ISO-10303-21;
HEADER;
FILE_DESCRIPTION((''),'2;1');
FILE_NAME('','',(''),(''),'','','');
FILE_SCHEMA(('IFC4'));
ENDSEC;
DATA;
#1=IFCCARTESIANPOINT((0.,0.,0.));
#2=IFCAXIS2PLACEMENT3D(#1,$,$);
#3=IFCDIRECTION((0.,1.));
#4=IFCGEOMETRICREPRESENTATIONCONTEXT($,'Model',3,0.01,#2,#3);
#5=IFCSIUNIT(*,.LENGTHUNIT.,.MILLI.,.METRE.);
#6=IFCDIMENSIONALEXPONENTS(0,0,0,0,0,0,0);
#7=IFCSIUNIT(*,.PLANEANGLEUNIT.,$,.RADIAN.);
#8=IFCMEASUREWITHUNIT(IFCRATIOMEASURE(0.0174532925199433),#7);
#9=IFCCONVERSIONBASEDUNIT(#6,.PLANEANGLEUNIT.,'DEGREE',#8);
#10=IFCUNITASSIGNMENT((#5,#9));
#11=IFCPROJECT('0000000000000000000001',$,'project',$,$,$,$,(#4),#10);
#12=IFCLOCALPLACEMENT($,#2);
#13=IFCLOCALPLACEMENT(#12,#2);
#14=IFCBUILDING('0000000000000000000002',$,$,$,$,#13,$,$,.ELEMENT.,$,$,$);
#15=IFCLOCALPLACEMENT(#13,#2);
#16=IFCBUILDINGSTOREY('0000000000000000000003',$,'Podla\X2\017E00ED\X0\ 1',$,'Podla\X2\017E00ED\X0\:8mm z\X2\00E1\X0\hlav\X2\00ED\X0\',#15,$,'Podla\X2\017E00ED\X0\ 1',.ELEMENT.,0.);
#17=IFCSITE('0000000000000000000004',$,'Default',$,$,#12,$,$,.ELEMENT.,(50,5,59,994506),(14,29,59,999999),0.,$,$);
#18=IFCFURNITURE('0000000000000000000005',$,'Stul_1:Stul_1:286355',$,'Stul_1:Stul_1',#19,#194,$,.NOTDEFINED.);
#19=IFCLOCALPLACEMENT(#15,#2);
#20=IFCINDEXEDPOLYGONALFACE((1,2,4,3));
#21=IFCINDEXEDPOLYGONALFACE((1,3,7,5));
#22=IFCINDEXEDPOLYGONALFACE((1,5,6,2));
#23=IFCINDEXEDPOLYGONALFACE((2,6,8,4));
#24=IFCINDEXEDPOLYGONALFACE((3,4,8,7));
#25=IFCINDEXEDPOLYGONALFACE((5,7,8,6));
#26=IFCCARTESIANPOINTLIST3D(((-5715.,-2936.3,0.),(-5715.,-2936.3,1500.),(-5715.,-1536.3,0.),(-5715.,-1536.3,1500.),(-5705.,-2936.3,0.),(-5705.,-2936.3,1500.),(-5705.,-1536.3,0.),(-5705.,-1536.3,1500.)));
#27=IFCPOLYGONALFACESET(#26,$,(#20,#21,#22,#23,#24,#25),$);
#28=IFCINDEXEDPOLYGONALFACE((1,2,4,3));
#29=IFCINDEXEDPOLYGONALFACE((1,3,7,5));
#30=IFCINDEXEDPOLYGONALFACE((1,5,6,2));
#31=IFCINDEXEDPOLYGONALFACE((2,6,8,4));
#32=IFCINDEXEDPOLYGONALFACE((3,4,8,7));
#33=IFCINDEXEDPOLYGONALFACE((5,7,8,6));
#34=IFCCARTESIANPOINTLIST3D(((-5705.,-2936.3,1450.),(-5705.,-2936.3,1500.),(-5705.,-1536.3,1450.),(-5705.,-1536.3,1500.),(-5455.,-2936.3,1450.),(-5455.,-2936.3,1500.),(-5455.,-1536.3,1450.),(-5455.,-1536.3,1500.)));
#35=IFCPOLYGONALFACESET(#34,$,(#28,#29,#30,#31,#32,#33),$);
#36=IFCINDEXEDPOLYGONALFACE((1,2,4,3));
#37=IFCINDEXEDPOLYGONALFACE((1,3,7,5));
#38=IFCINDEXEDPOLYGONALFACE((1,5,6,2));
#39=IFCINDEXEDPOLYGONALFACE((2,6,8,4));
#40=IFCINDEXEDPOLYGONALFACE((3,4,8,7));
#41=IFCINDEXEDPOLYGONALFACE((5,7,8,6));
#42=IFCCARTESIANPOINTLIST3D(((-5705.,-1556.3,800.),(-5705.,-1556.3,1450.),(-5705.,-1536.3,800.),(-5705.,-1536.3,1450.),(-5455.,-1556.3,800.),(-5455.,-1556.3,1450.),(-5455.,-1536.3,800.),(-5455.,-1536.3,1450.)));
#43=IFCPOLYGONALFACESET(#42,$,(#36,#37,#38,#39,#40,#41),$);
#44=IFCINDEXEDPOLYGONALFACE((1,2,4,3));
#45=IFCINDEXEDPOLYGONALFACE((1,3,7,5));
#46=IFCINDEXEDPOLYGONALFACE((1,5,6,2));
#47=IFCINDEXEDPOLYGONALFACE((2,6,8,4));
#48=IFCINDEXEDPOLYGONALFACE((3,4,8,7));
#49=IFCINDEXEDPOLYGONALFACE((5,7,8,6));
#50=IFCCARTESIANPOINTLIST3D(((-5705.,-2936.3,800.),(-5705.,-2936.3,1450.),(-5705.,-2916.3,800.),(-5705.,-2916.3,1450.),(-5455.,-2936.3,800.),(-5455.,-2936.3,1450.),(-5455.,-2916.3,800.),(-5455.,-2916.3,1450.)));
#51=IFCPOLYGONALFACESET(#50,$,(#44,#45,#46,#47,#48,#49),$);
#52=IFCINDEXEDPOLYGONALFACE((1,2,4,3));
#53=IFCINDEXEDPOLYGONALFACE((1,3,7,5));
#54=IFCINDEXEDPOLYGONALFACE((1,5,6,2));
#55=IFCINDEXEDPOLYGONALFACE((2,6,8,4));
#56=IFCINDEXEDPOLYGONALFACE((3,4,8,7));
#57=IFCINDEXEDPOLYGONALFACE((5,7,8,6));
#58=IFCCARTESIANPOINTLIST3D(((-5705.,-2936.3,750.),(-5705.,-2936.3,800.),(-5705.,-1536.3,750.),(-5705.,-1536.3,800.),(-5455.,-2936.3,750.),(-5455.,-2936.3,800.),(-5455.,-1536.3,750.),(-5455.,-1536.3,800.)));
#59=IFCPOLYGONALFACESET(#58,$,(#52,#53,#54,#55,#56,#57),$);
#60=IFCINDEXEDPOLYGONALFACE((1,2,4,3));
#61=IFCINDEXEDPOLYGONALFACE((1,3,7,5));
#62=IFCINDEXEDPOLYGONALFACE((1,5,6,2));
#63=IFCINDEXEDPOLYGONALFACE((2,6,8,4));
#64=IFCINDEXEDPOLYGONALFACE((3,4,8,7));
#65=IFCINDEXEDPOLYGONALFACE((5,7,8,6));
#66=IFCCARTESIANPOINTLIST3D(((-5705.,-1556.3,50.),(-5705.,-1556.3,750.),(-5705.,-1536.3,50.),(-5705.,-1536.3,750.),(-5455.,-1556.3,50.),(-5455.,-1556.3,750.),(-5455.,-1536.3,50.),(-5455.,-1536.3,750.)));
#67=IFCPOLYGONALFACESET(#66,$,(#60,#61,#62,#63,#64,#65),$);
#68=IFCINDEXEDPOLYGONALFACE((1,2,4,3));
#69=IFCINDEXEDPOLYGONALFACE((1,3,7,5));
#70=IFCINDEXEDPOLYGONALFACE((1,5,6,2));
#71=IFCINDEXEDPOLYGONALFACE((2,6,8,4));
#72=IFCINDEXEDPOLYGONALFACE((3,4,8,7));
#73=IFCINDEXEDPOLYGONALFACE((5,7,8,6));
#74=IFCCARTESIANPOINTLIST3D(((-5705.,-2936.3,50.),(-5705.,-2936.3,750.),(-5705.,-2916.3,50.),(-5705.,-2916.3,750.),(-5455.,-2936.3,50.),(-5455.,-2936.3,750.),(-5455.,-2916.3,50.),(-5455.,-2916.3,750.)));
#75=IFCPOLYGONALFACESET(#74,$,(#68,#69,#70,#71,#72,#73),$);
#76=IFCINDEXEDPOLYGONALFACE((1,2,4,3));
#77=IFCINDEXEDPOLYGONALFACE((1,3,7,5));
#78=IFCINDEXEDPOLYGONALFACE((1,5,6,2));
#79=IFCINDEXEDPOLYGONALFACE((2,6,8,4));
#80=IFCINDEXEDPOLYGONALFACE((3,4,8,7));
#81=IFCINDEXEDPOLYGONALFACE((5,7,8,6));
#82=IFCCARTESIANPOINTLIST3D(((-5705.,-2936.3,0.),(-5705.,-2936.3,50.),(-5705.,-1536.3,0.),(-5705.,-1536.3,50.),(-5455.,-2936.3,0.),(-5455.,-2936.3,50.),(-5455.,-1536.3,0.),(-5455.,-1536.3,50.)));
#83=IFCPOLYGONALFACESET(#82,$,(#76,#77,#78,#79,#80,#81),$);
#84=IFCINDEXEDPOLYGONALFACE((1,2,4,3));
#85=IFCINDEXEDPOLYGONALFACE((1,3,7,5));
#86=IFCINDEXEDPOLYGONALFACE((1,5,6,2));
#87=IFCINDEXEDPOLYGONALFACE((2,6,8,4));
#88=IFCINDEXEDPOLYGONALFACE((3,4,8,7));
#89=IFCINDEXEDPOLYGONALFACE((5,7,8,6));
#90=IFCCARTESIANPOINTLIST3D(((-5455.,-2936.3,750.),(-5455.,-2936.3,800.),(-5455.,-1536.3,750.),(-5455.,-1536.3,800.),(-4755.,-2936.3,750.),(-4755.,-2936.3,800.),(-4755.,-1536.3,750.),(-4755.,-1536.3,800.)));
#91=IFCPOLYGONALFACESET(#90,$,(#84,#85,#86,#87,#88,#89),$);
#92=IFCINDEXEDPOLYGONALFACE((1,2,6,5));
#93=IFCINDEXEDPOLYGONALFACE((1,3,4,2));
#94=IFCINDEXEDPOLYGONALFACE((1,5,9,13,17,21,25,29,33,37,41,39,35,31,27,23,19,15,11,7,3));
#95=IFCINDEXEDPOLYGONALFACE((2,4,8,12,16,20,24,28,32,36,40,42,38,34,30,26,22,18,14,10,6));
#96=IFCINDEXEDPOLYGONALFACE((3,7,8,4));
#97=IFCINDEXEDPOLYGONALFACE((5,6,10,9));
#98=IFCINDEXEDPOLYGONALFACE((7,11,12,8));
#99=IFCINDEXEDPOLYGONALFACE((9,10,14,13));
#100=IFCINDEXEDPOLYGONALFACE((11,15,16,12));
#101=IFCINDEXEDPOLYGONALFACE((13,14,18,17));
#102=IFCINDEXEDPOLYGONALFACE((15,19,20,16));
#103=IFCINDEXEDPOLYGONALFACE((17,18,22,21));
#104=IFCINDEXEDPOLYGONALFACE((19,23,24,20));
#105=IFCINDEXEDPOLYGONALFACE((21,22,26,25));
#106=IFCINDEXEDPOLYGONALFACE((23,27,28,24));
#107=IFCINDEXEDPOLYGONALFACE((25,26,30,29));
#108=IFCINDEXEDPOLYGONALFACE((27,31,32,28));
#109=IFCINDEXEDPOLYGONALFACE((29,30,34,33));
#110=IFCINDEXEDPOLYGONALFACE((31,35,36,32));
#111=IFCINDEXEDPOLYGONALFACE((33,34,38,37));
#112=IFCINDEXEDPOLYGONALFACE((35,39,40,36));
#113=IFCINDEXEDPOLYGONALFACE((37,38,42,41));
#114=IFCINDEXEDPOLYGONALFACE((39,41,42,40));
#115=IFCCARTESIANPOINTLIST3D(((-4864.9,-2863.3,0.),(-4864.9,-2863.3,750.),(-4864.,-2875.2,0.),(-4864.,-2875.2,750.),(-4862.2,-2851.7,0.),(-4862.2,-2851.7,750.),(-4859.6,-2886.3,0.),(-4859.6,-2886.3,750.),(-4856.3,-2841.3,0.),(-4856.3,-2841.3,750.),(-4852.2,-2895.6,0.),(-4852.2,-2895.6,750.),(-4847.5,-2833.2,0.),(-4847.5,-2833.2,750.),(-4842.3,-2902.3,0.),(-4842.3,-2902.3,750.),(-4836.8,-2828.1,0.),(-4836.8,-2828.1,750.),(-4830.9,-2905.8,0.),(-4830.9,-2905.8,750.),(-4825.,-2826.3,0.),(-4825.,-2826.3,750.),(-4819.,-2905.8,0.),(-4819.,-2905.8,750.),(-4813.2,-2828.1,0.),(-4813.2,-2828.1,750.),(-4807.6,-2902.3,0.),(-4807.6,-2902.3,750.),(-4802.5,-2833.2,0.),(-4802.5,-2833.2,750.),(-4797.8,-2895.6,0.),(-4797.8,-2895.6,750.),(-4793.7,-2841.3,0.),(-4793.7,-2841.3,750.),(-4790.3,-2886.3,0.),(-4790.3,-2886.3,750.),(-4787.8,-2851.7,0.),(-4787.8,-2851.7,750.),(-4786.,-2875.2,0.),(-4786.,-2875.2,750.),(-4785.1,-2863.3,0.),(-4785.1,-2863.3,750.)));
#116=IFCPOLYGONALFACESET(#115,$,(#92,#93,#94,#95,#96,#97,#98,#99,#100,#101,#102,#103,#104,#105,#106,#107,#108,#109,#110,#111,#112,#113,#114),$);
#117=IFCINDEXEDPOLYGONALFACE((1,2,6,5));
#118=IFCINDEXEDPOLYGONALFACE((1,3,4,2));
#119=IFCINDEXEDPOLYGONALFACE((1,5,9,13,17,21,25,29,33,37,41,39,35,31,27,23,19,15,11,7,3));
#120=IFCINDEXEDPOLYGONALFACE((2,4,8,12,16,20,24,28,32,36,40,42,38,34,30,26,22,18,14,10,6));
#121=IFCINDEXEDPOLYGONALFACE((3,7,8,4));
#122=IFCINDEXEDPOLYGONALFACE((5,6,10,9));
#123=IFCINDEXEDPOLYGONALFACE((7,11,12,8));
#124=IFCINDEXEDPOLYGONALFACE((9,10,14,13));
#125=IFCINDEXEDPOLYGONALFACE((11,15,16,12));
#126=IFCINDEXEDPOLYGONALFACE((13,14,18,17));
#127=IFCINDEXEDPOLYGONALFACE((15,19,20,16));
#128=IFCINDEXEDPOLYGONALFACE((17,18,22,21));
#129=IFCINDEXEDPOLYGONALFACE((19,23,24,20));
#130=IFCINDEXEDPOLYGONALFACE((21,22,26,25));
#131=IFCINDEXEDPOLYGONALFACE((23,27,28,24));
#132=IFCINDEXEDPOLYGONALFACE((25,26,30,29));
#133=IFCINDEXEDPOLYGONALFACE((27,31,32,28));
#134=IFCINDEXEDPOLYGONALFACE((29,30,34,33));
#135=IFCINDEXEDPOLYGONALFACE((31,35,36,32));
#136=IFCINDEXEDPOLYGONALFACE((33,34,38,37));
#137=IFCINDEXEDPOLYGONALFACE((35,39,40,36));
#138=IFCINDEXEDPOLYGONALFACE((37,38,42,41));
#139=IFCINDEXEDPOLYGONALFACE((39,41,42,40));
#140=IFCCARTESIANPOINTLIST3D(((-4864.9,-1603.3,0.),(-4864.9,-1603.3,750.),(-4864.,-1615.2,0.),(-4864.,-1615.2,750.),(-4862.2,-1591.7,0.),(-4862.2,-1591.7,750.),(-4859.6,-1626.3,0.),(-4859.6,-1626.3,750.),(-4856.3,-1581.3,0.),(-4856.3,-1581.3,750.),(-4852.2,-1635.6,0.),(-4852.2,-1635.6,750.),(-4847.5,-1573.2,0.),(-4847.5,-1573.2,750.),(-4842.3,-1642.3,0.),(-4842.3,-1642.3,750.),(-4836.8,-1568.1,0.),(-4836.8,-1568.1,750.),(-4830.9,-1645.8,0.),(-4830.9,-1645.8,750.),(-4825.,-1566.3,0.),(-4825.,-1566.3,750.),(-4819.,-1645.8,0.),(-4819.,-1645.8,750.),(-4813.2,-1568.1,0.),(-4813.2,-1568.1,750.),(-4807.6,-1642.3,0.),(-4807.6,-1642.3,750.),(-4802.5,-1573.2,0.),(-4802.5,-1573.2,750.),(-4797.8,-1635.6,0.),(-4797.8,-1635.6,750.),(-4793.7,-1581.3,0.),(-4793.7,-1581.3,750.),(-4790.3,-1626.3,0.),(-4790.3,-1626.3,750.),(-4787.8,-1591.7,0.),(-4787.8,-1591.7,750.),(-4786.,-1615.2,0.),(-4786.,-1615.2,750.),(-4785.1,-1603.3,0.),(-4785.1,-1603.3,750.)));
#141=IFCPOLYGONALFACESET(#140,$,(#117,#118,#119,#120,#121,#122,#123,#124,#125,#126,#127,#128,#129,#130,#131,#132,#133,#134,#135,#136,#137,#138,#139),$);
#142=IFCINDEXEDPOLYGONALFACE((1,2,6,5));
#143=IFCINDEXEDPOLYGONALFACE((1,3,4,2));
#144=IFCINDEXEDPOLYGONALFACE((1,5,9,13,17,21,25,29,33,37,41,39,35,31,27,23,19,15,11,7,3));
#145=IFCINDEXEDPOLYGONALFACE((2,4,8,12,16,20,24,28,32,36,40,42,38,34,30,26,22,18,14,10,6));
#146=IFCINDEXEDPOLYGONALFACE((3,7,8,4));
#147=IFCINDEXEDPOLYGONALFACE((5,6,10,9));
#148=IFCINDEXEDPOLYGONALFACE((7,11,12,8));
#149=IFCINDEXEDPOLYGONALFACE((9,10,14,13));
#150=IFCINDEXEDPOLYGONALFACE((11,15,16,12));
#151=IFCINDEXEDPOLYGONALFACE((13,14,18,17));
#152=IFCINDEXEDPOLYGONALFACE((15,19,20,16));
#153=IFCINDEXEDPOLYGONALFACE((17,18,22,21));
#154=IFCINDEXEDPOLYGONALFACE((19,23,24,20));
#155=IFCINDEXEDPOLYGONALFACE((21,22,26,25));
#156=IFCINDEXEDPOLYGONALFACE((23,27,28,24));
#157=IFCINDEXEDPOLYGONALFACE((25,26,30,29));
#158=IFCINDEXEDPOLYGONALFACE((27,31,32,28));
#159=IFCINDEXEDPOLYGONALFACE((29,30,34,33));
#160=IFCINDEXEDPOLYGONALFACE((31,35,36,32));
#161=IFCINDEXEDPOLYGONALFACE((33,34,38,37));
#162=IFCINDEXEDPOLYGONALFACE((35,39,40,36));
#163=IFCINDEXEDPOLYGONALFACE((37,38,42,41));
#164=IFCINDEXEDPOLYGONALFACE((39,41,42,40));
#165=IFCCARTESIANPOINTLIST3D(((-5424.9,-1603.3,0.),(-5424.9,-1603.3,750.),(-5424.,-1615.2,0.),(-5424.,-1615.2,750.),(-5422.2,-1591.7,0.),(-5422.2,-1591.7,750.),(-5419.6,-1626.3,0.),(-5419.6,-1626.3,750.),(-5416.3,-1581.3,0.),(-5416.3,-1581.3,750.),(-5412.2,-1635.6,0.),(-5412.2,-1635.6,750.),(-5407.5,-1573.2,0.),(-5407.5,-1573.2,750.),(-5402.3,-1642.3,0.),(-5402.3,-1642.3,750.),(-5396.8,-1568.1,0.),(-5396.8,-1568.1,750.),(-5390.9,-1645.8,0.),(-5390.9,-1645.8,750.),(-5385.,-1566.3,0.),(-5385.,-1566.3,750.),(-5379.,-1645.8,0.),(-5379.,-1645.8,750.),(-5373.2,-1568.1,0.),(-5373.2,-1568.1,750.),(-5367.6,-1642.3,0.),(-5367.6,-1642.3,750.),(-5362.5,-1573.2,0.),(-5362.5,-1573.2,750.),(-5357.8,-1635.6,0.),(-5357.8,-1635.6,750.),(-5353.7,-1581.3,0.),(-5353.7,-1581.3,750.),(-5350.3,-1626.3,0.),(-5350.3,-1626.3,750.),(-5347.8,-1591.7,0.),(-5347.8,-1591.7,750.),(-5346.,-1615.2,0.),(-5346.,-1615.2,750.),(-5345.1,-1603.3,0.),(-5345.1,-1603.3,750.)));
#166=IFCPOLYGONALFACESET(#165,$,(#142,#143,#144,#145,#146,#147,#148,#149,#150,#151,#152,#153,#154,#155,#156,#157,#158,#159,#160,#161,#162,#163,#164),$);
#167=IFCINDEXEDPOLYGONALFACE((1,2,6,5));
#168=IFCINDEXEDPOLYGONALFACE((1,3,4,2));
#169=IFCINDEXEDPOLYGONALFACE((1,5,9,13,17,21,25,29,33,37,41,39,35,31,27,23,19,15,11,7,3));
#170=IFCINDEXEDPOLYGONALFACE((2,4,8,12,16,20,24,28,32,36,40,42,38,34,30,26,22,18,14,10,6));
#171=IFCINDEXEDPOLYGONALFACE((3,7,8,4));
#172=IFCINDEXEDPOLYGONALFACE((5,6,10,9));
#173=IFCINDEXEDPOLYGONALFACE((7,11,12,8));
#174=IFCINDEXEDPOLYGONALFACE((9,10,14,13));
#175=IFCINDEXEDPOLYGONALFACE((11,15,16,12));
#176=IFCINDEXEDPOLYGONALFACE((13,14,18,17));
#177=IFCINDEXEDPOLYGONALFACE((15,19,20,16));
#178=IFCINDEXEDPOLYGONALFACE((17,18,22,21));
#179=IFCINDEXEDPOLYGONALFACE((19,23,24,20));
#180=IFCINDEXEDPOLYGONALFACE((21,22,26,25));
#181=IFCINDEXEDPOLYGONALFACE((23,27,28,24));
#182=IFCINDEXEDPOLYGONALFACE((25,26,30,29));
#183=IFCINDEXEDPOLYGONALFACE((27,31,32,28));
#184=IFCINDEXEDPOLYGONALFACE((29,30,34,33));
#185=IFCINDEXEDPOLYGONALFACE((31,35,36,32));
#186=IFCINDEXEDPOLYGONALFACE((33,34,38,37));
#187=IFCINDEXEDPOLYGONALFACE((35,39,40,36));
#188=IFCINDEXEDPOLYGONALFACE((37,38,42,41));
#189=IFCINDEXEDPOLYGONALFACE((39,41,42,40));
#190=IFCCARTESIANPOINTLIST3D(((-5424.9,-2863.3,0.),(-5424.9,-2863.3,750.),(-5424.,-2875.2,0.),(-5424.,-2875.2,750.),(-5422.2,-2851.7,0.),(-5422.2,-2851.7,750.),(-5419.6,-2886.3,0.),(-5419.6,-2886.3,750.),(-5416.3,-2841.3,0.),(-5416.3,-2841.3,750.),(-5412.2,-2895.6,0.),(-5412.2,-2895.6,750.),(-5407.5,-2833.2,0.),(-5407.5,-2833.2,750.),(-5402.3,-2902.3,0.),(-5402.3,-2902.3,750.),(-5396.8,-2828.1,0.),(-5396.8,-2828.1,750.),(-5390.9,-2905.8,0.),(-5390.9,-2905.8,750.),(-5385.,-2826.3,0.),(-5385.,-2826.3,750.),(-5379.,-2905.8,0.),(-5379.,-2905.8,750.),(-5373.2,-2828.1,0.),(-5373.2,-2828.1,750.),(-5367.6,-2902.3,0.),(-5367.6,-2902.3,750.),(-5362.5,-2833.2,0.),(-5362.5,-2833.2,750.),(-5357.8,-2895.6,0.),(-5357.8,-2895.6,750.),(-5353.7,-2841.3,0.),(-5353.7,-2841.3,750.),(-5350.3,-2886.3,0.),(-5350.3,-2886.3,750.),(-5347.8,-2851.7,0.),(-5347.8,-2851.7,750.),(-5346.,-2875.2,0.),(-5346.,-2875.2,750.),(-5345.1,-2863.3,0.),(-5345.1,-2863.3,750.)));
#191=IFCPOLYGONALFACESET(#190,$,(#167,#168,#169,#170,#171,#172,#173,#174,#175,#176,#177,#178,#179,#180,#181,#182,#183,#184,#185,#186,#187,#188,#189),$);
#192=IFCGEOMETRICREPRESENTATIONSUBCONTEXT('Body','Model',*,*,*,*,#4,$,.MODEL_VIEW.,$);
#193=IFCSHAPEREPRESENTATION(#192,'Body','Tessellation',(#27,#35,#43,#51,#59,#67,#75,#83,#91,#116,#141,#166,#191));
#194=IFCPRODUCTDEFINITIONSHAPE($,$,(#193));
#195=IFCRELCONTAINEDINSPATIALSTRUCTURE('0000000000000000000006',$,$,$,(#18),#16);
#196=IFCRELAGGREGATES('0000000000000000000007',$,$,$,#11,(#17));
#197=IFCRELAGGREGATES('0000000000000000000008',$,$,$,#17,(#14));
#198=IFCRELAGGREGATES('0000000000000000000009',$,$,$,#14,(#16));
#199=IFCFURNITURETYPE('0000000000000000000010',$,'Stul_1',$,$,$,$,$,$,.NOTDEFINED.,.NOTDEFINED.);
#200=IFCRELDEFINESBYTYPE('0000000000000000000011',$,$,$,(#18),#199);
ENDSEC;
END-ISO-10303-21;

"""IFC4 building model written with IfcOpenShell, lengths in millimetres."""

from ifc_helpers import new_model, entity, si_unit, converted_unit, direction, frame, frame_2d, origin, origin_2d_with_axis, place, context, subcontext, project, spatial, rectangle, circle, extrude, source, transform, mapped, type_object, type_shapes, element, save


model = new_model("IFC4")

# Units and contexts
model_context = context("Model", 3, precision=0.01, world=origin(), true_north=direction((0.0, 1.0)))
body_context = subcontext(model_context, "Body", "Model", "MODEL_VIEW")
ifc_project = project(units=[si_unit("LENGTHUNIT", "METRE", prefix="MILLI"), converted_unit("PLANEANGLEUNIT", "DEGREE", entity("IfcRatioMeasure", 0.0174532925199433), si_unit("PLANEANGLEUNIT", "RADIAN"), dimensions=[0, 0, 0, 0, 0, 0, 0])], contexts=[model_context])

# Site, building, storey
site_placement = place(None, origin())
site = spatial("IfcSite", under=ifc_project, at=site_placement, Name="Default", CompositionType="ELEMENT", RefLatitude=(50, 5, 59, 994506), RefLongitude=(14, 29, 59, 999999), RefElevation=0.0)
building_placement = place(site_placement, origin())
building = spatial("IfcBuilding", under=site, at=building_placement, CompositionType="ELEMENT")
storey_placement = place(building_placement, origin())
storey = spatial("IfcBuildingStorey", under=building, at=storey_placement, Name="Podlaží 1", ObjectType="Podlaží:8mm záhlaví", LongName="Podlaží 1", CompositionType="ELEMENT", Elevation=0.0)

# Furniture
furniture_type = type_object("IfcFurnitureType", Name="Stul_1", AssemblyPlace="NOTDEFINED", PredefinedType="NOTDEFINED")
shared_shape_1 = source(origin(), body_context, "Body", "SweptSolid", [
    extrude(rectangle(XDim=1400.0, YDim=10.0, at=origin_2d_with_axis()), frame((0.0, 605.0, 0.0), z_axis=(0.0, 0.0, 1.0), x_axis=(-1.0, 0.0, 0.0)), (0.0, 0.0, 1.0), 1500.0),
    extrude(rectangle(XDim=1400.0, YDim=250.0, at=frame_2d((0.0, 0.0), x_axis=(1.0, 0.0))), frame((0.0, 475.0, 1450.0), z_axis=(0.0, 0.0, 1.0), x_axis=(-1.0, 0.0, 0.0)), (0.0, 0.0, 1.0), 50.0),
    extrude(rectangle(XDim=20.0, YDim=250.0, at=origin_2d_with_axis()), frame((690.0, 475.0, 800.0), z_axis=(0.0, 0.0, 1.0), x_axis=(-1.0, 0.0, 0.0)), (0.0, 0.0, 1.0), 650.0),
    extrude(rectangle(XDim=20.0, YDim=250.0, at=frame_2d((0.0, 0.0), x_axis=(1.0, 0.0))), frame((-690.0, 475.0, 800.0), z_axis=(0.0, 0.0, 1.0), x_axis=(-1.0, 0.0, 0.0)), (0.0, 0.0, 1.0), 650.0),
    extrude(rectangle(XDim=1400.0, YDim=250.0, at=origin_2d_with_axis()), frame((0.0, 475.0, 750.0), z_axis=(0.0, 0.0, 1.0), x_axis=(-1.0, 0.0, 0.0)), (0.0, 0.0, 1.0), 50.0),
    extrude(rectangle(XDim=20.0, YDim=250.0, at=origin_2d_with_axis()), frame((690.0, 475.0, 50.0), z_axis=(0.0, 0.0, 1.0), x_axis=(-1.0, 0.0, 0.0)), (0.0, 0.0, 1.0), 700.0),
    extrude(rectangle(XDim=20.0, YDim=250.0, at=frame_2d((0.0, 0.0), x_axis=(1.0, 0.0))), frame((-690.0, 475.0, 50.0), z_axis=(0.0, 0.0, 1.0), x_axis=(-1.0, 0.0, 0.0)), (0.0, 0.0, 1.0), 700.0),
    extrude(rectangle(XDim=1400.0, YDim=250.0, at=origin_2d_with_axis()), frame((0.0, 475.0, 0.0), z_axis=(0.0, 0.0, 1.0), x_axis=(-1.0, 0.0, 0.0)), (0.0, 0.0, 1.0), 50.0),
    extrude(rectangle(XDim=1400.0, YDim=700.0, at=origin_2d_with_axis()), frame((0.0, 0.0, 750.0), z_axis=(0.0, 0.0, 1.0), x_axis=(-1.0, 0.0, 0.0)), (0.0, 0.0, 1.0), 50.0),
    extrude(circle(Radius=40.0, at=frame_2d((0.0, 0.0), x_axis=(1.0, 0.0))), frame((-630.0, -280.0, 0.0)), (0.0, 0.0, 1.0), 750.0),
    extrude(circle(Radius=40.0, at=frame_2d((0.0, 0.0), x_axis=(1.0, 0.0))), frame((630.0, -280.0, 0.0)), (0.0, 0.0, 1.0), 750.0),
    extrude(circle(Radius=40.0, at=frame_2d((0.0, 0.0), x_axis=(1.0, 0.0))), frame((630.0, 280.0, 0.0)), (0.0, 0.0, 1.0), 750.0),
    extrude(circle(Radius=40.0, at=frame_2d((0.0, 0.0), x_axis=(1.0, 0.0))), frame((-630.0, 280.0, 0.0)), (0.0, 0.0, 1.0), 750.0),
])
type_shapes(furniture_type, [shared_shape_1])
for number, where, z_axis, x_axis, name in (
    (1, (-5105.0, -2236.3, 0.0), (0.0, 0.0, 1.0), (0.0, 1.0, 0.0), "Stul_1:Stul_1:286355"),
):
    element("IfcFurniture", number, at=place(storey_placement, frame(where, z_axis=z_axis, x_axis=x_axis)), inside=storey, type_object=furniture_type, Name=name, ObjectType="Stul_1:Stul_1", PredefinedType="NOTDEFINED", context=body_context, shape_type="MappedRepresentation", body=[
        mapped(shared_shape_1, transform((0.0, 0.0, 0.0), scale=1.0)),
    ])

save(model, "model.ifc")
